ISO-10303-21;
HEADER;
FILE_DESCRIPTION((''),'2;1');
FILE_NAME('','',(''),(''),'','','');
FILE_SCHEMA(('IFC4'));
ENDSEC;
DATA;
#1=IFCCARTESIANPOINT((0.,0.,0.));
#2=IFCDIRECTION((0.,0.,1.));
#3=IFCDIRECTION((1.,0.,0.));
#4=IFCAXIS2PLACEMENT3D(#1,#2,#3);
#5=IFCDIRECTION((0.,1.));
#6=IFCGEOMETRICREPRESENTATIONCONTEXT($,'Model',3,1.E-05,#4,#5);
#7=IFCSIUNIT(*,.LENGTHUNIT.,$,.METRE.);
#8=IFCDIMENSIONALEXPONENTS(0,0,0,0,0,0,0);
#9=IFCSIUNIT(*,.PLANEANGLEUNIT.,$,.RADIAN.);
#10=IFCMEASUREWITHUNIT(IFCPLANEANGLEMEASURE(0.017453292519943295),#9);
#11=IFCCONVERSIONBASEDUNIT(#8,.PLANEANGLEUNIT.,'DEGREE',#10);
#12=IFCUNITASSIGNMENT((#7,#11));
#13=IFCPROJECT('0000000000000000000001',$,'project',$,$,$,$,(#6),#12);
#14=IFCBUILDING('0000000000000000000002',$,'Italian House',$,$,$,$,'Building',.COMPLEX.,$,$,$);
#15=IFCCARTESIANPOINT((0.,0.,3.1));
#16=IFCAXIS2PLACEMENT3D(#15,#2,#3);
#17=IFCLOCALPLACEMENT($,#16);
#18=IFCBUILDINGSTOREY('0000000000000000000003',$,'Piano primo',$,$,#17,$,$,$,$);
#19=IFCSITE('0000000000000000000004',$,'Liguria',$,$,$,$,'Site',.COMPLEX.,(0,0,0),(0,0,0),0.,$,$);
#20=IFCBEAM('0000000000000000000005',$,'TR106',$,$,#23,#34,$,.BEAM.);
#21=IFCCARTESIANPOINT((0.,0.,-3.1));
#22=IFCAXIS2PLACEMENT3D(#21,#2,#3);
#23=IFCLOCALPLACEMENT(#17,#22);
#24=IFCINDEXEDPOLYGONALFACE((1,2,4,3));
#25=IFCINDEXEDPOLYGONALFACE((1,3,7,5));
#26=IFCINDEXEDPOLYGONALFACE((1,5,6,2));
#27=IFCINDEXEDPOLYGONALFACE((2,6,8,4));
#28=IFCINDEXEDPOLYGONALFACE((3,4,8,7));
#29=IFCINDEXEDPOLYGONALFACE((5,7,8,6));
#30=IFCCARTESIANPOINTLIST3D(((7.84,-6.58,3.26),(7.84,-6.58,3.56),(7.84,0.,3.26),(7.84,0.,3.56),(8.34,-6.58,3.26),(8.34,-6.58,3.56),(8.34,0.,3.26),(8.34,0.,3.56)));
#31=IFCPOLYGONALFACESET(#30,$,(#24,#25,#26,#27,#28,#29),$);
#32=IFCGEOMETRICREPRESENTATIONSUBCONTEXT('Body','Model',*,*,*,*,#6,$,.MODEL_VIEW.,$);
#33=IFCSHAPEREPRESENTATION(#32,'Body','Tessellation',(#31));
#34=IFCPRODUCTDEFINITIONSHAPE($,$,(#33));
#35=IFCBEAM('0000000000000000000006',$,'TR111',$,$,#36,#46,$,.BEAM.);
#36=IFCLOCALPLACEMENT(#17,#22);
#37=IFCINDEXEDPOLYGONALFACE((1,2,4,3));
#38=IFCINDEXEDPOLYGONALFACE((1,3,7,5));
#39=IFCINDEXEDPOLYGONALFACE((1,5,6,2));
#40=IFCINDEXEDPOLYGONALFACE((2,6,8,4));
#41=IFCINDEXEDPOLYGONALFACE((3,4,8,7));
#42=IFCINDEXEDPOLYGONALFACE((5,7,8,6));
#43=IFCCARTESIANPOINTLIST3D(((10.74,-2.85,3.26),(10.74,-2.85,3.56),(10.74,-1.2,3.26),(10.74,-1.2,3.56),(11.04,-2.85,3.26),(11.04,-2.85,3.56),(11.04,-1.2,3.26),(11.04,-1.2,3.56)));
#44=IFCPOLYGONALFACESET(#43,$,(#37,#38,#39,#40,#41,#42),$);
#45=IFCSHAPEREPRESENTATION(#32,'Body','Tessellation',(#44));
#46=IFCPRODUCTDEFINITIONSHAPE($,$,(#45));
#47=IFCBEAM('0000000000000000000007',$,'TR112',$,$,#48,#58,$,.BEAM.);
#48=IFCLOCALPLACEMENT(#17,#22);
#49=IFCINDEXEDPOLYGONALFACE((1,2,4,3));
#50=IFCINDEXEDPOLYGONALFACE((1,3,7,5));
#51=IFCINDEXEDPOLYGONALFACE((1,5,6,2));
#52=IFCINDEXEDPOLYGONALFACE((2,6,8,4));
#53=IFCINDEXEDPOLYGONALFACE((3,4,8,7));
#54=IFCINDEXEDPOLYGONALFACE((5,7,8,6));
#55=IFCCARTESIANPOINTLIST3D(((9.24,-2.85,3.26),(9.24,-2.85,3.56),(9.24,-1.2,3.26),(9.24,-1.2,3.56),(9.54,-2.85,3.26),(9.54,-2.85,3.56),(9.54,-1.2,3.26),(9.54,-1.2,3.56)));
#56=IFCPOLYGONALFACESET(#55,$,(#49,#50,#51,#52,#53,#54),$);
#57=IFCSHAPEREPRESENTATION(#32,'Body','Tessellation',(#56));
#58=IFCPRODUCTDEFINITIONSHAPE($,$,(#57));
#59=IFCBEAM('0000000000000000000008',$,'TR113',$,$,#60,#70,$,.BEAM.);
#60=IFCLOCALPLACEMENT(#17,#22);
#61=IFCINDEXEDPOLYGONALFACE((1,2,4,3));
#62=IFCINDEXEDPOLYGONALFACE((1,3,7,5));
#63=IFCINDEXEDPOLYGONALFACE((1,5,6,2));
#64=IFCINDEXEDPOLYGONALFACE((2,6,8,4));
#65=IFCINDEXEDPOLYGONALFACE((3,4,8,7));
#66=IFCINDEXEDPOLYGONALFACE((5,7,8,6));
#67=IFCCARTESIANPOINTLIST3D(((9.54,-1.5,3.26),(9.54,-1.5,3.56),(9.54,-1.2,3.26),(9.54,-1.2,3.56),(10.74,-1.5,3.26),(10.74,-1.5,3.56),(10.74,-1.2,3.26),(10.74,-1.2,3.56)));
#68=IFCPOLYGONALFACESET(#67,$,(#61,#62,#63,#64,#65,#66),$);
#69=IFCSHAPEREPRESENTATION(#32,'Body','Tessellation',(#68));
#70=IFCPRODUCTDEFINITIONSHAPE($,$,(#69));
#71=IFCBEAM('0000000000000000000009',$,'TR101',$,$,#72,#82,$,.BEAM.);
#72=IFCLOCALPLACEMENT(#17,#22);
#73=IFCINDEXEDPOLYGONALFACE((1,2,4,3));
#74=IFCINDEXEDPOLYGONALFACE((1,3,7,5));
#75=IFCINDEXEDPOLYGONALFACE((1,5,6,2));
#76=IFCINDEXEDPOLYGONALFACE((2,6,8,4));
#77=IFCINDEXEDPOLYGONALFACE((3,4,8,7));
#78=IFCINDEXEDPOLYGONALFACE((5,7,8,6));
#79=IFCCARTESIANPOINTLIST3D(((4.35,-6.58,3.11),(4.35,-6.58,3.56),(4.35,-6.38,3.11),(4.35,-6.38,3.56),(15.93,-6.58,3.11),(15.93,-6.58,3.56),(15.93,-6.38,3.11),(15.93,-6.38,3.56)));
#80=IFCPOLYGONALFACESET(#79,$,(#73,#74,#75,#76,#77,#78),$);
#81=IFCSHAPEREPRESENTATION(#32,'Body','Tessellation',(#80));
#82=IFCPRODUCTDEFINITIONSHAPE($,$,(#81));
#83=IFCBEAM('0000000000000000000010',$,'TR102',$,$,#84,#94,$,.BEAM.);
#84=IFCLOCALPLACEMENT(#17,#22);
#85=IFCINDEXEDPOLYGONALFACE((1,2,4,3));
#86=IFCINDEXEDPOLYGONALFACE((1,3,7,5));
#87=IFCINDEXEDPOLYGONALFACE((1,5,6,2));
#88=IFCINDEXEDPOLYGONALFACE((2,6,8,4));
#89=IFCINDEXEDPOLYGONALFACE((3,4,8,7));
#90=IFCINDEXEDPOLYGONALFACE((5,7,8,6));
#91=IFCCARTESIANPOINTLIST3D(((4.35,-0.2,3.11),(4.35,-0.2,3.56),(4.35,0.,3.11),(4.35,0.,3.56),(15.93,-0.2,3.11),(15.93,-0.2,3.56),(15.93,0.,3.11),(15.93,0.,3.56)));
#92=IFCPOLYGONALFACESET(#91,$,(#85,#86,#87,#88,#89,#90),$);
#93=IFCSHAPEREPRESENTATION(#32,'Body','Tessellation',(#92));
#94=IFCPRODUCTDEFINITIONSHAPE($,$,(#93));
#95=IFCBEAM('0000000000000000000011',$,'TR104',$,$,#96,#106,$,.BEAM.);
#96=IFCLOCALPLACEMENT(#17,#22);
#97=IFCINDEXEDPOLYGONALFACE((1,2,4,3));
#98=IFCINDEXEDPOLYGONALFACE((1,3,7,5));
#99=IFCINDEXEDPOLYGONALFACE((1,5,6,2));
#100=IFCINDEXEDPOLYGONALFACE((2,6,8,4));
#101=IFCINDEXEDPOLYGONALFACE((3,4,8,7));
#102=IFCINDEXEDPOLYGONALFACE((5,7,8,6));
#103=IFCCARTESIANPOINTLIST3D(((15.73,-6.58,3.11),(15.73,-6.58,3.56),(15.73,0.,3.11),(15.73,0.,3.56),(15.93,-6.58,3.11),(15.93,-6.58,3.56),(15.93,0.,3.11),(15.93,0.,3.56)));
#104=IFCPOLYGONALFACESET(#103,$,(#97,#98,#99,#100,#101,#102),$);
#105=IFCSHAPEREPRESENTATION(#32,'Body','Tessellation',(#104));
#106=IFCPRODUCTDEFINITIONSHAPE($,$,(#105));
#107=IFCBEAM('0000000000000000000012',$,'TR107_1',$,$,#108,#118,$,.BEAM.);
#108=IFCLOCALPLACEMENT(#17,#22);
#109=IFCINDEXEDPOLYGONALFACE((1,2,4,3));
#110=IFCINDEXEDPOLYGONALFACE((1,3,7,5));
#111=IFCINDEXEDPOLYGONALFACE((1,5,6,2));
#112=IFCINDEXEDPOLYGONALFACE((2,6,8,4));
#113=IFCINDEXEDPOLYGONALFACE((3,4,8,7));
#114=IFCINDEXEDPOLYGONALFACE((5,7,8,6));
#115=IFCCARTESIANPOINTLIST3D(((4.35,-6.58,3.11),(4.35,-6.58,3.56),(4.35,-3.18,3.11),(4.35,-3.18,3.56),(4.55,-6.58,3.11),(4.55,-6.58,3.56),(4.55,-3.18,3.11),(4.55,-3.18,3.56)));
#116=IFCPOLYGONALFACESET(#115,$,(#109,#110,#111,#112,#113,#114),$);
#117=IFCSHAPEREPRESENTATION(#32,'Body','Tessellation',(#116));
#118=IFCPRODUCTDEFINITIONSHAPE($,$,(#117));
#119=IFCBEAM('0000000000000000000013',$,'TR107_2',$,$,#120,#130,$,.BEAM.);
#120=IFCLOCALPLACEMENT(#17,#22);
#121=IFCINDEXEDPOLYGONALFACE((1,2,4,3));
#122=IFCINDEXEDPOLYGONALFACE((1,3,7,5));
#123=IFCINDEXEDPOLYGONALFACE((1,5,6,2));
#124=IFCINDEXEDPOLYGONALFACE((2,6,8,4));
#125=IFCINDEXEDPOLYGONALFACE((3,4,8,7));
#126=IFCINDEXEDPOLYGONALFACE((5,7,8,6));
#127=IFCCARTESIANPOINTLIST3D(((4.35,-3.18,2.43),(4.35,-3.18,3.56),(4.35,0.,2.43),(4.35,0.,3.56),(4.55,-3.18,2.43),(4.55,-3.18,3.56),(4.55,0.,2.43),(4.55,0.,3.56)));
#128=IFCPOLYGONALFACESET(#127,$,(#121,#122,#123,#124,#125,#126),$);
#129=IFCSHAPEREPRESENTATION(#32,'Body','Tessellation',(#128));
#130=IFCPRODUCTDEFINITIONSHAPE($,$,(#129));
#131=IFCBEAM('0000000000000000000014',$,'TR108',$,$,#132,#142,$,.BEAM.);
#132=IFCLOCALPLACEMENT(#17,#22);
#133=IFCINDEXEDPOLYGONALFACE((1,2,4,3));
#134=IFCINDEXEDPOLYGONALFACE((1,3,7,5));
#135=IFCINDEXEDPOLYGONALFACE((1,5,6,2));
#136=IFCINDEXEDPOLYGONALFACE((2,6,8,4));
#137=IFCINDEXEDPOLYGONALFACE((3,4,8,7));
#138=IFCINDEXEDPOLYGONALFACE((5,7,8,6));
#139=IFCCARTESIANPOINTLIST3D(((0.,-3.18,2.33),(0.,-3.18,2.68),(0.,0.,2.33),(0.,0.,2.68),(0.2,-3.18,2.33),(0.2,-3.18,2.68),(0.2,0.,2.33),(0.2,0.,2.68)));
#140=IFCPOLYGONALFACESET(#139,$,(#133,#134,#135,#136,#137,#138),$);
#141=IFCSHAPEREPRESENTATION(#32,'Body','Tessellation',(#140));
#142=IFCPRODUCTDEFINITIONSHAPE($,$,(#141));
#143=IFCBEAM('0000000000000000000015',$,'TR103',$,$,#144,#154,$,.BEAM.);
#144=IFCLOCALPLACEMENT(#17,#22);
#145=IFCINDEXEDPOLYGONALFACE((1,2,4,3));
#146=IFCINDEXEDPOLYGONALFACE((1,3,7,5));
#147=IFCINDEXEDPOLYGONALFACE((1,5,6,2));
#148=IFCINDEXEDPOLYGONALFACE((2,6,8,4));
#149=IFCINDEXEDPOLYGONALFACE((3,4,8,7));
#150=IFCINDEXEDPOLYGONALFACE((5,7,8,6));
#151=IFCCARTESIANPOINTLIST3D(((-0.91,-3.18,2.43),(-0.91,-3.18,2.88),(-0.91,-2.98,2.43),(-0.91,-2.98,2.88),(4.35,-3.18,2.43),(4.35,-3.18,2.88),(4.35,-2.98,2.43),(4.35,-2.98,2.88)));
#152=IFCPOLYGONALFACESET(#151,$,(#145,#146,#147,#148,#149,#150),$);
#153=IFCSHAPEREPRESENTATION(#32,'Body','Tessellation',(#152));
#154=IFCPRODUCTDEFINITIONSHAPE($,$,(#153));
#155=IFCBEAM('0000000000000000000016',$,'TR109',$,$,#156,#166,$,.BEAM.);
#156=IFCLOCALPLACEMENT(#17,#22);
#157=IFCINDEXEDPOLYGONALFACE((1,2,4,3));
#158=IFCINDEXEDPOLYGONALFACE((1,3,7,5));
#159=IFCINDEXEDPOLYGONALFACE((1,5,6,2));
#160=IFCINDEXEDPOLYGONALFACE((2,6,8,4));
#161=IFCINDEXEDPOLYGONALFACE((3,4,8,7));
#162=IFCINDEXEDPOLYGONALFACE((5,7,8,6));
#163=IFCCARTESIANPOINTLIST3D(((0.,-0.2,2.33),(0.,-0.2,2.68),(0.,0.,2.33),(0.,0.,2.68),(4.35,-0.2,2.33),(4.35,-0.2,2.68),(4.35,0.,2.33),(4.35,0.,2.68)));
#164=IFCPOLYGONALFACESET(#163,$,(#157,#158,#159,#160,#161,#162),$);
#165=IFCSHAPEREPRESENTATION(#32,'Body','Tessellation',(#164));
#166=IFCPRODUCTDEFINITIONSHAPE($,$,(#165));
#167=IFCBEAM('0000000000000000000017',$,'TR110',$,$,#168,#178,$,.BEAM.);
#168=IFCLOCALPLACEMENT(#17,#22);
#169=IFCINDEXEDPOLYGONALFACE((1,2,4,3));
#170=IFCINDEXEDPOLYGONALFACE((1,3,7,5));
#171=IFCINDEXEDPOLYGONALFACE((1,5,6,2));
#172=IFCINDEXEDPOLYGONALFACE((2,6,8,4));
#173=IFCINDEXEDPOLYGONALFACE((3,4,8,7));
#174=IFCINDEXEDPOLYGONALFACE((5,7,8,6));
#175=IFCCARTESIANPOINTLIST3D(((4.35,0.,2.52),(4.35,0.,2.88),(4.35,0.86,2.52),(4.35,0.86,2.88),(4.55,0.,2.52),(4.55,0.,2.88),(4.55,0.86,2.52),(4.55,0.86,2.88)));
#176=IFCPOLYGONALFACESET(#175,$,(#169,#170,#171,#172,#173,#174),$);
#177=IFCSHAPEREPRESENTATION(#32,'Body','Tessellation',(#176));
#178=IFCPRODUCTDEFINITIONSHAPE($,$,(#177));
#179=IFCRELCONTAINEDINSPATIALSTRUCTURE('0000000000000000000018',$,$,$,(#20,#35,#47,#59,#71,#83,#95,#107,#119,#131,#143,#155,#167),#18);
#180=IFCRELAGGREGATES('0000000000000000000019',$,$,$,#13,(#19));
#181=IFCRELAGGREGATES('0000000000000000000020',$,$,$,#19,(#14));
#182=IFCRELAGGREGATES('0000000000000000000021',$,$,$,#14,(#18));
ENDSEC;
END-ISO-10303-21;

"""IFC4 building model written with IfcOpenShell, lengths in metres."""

from ifc_helpers import new_model, entity, si_unit, converted_unit, direction, frame, frame_2d, origin_with_axes, place, context, subcontext, project, spatial, rectangle, extrude, element, save


model = new_model("IFC4")

# Units and contexts
model_context = context("Model", 3, precision=1e-05, world=origin_with_axes(), true_north=direction((0.0, 1.0)))
body_context = subcontext(model_context, "Body", "Model", "MODEL_VIEW")
ifc_project = project(units=[si_unit("LENGTHUNIT", "METRE"), converted_unit("PLANEANGLEUNIT", "DEGREE", entity("IfcPlaneAngleMeasure", 0.017453292519943295), si_unit("PLANEANGLEUNIT", "RADIAN"), dimensions=[0, 0, 0, 0, 0, 0, 0])], contexts=[model_context])

# Site, building, storey
site = spatial("IfcSite", under=ifc_project, Name="Liguria", LongName="Site", CompositionType="COMPLEX", RefLatitude=(0, 0, 0), RefLongitude=(0, 0, 0), RefElevation=0.0)
building = spatial("IfcBuilding", under=site, Name="Italian House", LongName="Building", CompositionType="COMPLEX")
storey_placement = place(None, frame((0.0, 0.0, 3.1), z_axis=(0.0, 0.0, 1.0), x_axis=(1.0, 0.0, 0.0)))
storey = spatial("IfcBuildingStorey", under=building, at=storey_placement, Name="Piano primo")

# Beams
beam_1_placement = place(storey_placement, frame((0.0, 0.0, -3.1), z_axis=(0.0, 0.0, 1.0), x_axis=(1.0, 0.0, 0.0)))
element("IfcBeam", 1, at=beam_1_placement, inside=storey, Name="TR106", PredefinedType="BEAM", context=body_context, shape_type="SweptSolid", body=[
    extrude(rectangle(XDim=0.5, YDim=0.3, at=frame_2d((0.0, 0.0), x_axis=(0.0, 1.0))), frame((8.09, -6.58, 3.41), z_axis=(0.0, 1.0, 0.0), x_axis=(0.0, 0.0, -1.0)), (0.0, 0.0, 1.0), 6.58),
])
beam_2_placement = place(storey_placement, frame((0.0, 0.0, -3.1), z_axis=(0.0, 0.0, 1.0), x_axis=(1.0, 0.0, 0.0)))
element("IfcBeam", 2, at=beam_2_placement, inside=storey, Name="TR111", PredefinedType="BEAM", context=body_context, shape_type="SweptSolid", body=[
    extrude(rectangle(XDim=0.3, YDim=0.3, at=frame_2d((0.0, 0.0), x_axis=(0.0, 1.0))), frame((10.89, -2.85, 3.41), z_axis=(0.0, 1.0, 0.0), x_axis=(0.0, 0.0, -1.0)), (0.0, 0.0, 1.0), 1.65),
])
beam_3_placement = place(storey_placement, frame((0.0, 0.0, -3.1), z_axis=(0.0, 0.0, 1.0), x_axis=(1.0, 0.0, 0.0)))
element("IfcBeam", 3, at=beam_3_placement, inside=storey, Name="TR112", PredefinedType="BEAM", context=body_context, shape_type="SweptSolid", body=[
    extrude(rectangle(XDim=0.3, YDim=0.3, at=frame_2d((0.0, 0.0), x_axis=(0.0, 1.0))), frame((9.39, -2.85, 3.41), z_axis=(0.0, 1.0, 0.0), x_axis=(0.0, 0.0, -1.0)), (0.0, 0.0, 1.0), 1.65),
])
beam_4_placement = place(storey_placement, frame((0.0, 0.0, -3.1), z_axis=(0.0, 0.0, 1.0), x_axis=(1.0, 0.0, 0.0)))
element("IfcBeam", 4, at=beam_4_placement, inside=storey, Name="TR113", PredefinedType="BEAM", context=body_context, shape_type="SweptSolid", body=[
    extrude(rectangle(XDim=0.3, YDim=0.3, at=frame_2d((0.0, 0.0), x_axis=(0.0, 1.0))), frame((10.74, -1.35, 3.41), z_axis=(-1.0, 0.0, 0.0), x_axis=(0.0, 0.0, -1.0)), (0.0, 0.0, 1.0), 1.2),
])
beam_5_placement = place(storey_placement, frame((0.0, 0.0, -3.1), z_axis=(0.0, 0.0, 1.0), x_axis=(1.0, 0.0, 0.0)))
element("IfcBeam", 5, at=beam_5_placement, inside=storey, Name="TR101", PredefinedType="BEAM", context=body_context, shape_type="SweptSolid", body=[
    extrude(rectangle(XDim=0.2, YDim=0.45, at=frame_2d((0.0, 0.0), x_axis=(0.0, 1.0))), frame((4.35, -6.48, 3.335), z_axis=(1.0, 0.0, 0.0), x_axis=(0.0, 0.0, -1.0)), (0.0, 0.0, 1.0), 11.58),
])
beam_6_placement = place(storey_placement, frame((0.0, 0.0, -3.1), z_axis=(0.0, 0.0, 1.0), x_axis=(1.0, 0.0, 0.0)))
element("IfcBeam", 6, at=beam_6_placement, inside=storey, Name="TR102", PredefinedType="BEAM", context=body_context, shape_type="SweptSolid", body=[
    extrude(rectangle(XDim=0.2, YDim=0.45, at=frame_2d((0.0, 0.0), x_axis=(0.0, 1.0))), frame((4.35, -0.1, 3.335), z_axis=(1.0, 0.0, 0.0), x_axis=(0.0, 0.0, -1.0)), (0.0, 0.0, 1.0), 11.58),
])
beam_7_placement = place(storey_placement, frame((0.0, 0.0, -3.1), z_axis=(0.0, 0.0, 1.0), x_axis=(1.0, 0.0, 0.0)))
element("IfcBeam", 7, at=beam_7_placement, inside=storey, Name="TR104", PredefinedType="BEAM", context=body_context, shape_type="SweptSolid", body=[
    extrude(rectangle(XDim=0.2, YDim=0.45, at=frame_2d((0.0, 0.0), x_axis=(0.0, 1.0))), frame((15.83, -6.58, 3.335), z_axis=(0.0, 1.0, 0.0), x_axis=(0.0, 0.0, -1.0)), (0.0, 0.0, 1.0), 6.58),
])
beam_8_placement = place(storey_placement, frame((0.0, 0.0, -3.1), z_axis=(0.0, 0.0, 1.0), x_axis=(1.0, 0.0, 0.0)))
element("IfcBeam", 8, at=beam_8_placement, inside=storey, Name="TR107_1", PredefinedType="BEAM", context=body_context, shape_type="SweptSolid", body=[
    extrude(rectangle(XDim=0.2, YDim=0.45, at=frame_2d((0.0, 0.0), x_axis=(0.0, 1.0))), frame((4.45, -6.58, 3.335), z_axis=(0.0, 1.0, 0.0), x_axis=(0.0, 0.0, -1.0)), (0.0, 0.0, 1.0), 3.4),
])
beam_9_placement = place(storey_placement, frame((0.0, 0.0, -3.1), z_axis=(0.0, 0.0, 1.0), x_axis=(1.0, 0.0, 0.0)))
element("IfcBeam", 9, at=beam_9_placement, inside=storey, Name="TR107_2", PredefinedType="BEAM", context=body_context, shape_type="SweptSolid", body=[
    extrude(rectangle(XDim=0.2, YDim=1.13, at=frame_2d((0.0, 0.0), x_axis=(0.0, 1.0))), frame((4.45, -3.18, 2.995), z_axis=(0.0, 1.0, 0.0), x_axis=(0.0, 0.0, -1.0)), (0.0, 0.0, 1.0), 3.18),
])
beam_10_placement = place(storey_placement, frame((0.0, 0.0, -3.1), z_axis=(0.0, 0.0, 1.0), x_axis=(1.0, 0.0, 0.0)))
element("IfcBeam", 10, at=beam_10_placement, inside=storey, Name="TR108", PredefinedType="BEAM", context=body_context, shape_type="SweptSolid", body=[
    extrude(rectangle(XDim=0.2, YDim=0.35, at=frame_2d((0.0, 0.0), x_axis=(0.0, 1.0))), frame((0.1, -3.18, 2.505), z_axis=(0.0, 1.0, 0.0), x_axis=(0.0, 0.0, -1.0)), (0.0, 0.0, 1.0), 3.18),
])
beam_11_placement = place(storey_placement, frame((0.0, 0.0, -3.1), z_axis=(0.0, 0.0, 1.0), x_axis=(1.0, 0.0, 0.0)))
element("IfcBeam", 11, at=beam_11_placement, inside=storey, Name="TR103", PredefinedType="BEAM", context=body_context, shape_type="SweptSolid", body=[
    extrude(rectangle(XDim=0.2, YDim=0.45, at=frame_2d((0.0, 0.0), x_axis=(0.0, 1.0))), frame((-0.91, -3.08, 2.655), z_axis=(1.0, 0.0, 0.0), x_axis=(0.0, 0.0, -1.0)), (0.0, 0.0, 1.0), 5.26),
])
beam_12_placement = place(storey_placement, frame((0.0, 0.0, -3.1), z_axis=(0.0, 0.0, 1.0), x_axis=(1.0, 0.0, 0.0)))
element("IfcBeam", 12, at=beam_12_placement, inside=storey, Name="TR109", PredefinedType="BEAM", context=body_context, shape_type="SweptSolid", body=[
    extrude(rectangle(XDim=0.2, YDim=0.35, at=frame_2d((0.0, 0.0), x_axis=(0.0, 1.0))), frame((0.0, -0.1, 2.505), z_axis=(1.0, 0.0, 0.0), x_axis=(0.0, 0.0, -1.0)), (0.0, 0.0, 1.0), 4.35),
])
beam_13_placement = place(storey_placement, frame((0.0, 0.0, -3.1), z_axis=(0.0, 0.0, 1.0), x_axis=(1.0, 0.0, 0.0)))
element("IfcBeam", 13, at=beam_13_placement, inside=storey, Name="TR110", PredefinedType="BEAM", context=body_context, shape_type="SweptSolid", body=[
    extrude(rectangle(XDim=0.2, YDim=0.36, at=frame_2d((0.0, 0.0), x_axis=(0.0, 1.0))), frame((4.45, 0.0, 2.7), z_axis=(0.0, 1.0, 0.0), x_axis=(0.0, 0.0, -1.0)), (0.0, 0.0, 1.0), 0.86),
])

save(model, "model.ifc")
